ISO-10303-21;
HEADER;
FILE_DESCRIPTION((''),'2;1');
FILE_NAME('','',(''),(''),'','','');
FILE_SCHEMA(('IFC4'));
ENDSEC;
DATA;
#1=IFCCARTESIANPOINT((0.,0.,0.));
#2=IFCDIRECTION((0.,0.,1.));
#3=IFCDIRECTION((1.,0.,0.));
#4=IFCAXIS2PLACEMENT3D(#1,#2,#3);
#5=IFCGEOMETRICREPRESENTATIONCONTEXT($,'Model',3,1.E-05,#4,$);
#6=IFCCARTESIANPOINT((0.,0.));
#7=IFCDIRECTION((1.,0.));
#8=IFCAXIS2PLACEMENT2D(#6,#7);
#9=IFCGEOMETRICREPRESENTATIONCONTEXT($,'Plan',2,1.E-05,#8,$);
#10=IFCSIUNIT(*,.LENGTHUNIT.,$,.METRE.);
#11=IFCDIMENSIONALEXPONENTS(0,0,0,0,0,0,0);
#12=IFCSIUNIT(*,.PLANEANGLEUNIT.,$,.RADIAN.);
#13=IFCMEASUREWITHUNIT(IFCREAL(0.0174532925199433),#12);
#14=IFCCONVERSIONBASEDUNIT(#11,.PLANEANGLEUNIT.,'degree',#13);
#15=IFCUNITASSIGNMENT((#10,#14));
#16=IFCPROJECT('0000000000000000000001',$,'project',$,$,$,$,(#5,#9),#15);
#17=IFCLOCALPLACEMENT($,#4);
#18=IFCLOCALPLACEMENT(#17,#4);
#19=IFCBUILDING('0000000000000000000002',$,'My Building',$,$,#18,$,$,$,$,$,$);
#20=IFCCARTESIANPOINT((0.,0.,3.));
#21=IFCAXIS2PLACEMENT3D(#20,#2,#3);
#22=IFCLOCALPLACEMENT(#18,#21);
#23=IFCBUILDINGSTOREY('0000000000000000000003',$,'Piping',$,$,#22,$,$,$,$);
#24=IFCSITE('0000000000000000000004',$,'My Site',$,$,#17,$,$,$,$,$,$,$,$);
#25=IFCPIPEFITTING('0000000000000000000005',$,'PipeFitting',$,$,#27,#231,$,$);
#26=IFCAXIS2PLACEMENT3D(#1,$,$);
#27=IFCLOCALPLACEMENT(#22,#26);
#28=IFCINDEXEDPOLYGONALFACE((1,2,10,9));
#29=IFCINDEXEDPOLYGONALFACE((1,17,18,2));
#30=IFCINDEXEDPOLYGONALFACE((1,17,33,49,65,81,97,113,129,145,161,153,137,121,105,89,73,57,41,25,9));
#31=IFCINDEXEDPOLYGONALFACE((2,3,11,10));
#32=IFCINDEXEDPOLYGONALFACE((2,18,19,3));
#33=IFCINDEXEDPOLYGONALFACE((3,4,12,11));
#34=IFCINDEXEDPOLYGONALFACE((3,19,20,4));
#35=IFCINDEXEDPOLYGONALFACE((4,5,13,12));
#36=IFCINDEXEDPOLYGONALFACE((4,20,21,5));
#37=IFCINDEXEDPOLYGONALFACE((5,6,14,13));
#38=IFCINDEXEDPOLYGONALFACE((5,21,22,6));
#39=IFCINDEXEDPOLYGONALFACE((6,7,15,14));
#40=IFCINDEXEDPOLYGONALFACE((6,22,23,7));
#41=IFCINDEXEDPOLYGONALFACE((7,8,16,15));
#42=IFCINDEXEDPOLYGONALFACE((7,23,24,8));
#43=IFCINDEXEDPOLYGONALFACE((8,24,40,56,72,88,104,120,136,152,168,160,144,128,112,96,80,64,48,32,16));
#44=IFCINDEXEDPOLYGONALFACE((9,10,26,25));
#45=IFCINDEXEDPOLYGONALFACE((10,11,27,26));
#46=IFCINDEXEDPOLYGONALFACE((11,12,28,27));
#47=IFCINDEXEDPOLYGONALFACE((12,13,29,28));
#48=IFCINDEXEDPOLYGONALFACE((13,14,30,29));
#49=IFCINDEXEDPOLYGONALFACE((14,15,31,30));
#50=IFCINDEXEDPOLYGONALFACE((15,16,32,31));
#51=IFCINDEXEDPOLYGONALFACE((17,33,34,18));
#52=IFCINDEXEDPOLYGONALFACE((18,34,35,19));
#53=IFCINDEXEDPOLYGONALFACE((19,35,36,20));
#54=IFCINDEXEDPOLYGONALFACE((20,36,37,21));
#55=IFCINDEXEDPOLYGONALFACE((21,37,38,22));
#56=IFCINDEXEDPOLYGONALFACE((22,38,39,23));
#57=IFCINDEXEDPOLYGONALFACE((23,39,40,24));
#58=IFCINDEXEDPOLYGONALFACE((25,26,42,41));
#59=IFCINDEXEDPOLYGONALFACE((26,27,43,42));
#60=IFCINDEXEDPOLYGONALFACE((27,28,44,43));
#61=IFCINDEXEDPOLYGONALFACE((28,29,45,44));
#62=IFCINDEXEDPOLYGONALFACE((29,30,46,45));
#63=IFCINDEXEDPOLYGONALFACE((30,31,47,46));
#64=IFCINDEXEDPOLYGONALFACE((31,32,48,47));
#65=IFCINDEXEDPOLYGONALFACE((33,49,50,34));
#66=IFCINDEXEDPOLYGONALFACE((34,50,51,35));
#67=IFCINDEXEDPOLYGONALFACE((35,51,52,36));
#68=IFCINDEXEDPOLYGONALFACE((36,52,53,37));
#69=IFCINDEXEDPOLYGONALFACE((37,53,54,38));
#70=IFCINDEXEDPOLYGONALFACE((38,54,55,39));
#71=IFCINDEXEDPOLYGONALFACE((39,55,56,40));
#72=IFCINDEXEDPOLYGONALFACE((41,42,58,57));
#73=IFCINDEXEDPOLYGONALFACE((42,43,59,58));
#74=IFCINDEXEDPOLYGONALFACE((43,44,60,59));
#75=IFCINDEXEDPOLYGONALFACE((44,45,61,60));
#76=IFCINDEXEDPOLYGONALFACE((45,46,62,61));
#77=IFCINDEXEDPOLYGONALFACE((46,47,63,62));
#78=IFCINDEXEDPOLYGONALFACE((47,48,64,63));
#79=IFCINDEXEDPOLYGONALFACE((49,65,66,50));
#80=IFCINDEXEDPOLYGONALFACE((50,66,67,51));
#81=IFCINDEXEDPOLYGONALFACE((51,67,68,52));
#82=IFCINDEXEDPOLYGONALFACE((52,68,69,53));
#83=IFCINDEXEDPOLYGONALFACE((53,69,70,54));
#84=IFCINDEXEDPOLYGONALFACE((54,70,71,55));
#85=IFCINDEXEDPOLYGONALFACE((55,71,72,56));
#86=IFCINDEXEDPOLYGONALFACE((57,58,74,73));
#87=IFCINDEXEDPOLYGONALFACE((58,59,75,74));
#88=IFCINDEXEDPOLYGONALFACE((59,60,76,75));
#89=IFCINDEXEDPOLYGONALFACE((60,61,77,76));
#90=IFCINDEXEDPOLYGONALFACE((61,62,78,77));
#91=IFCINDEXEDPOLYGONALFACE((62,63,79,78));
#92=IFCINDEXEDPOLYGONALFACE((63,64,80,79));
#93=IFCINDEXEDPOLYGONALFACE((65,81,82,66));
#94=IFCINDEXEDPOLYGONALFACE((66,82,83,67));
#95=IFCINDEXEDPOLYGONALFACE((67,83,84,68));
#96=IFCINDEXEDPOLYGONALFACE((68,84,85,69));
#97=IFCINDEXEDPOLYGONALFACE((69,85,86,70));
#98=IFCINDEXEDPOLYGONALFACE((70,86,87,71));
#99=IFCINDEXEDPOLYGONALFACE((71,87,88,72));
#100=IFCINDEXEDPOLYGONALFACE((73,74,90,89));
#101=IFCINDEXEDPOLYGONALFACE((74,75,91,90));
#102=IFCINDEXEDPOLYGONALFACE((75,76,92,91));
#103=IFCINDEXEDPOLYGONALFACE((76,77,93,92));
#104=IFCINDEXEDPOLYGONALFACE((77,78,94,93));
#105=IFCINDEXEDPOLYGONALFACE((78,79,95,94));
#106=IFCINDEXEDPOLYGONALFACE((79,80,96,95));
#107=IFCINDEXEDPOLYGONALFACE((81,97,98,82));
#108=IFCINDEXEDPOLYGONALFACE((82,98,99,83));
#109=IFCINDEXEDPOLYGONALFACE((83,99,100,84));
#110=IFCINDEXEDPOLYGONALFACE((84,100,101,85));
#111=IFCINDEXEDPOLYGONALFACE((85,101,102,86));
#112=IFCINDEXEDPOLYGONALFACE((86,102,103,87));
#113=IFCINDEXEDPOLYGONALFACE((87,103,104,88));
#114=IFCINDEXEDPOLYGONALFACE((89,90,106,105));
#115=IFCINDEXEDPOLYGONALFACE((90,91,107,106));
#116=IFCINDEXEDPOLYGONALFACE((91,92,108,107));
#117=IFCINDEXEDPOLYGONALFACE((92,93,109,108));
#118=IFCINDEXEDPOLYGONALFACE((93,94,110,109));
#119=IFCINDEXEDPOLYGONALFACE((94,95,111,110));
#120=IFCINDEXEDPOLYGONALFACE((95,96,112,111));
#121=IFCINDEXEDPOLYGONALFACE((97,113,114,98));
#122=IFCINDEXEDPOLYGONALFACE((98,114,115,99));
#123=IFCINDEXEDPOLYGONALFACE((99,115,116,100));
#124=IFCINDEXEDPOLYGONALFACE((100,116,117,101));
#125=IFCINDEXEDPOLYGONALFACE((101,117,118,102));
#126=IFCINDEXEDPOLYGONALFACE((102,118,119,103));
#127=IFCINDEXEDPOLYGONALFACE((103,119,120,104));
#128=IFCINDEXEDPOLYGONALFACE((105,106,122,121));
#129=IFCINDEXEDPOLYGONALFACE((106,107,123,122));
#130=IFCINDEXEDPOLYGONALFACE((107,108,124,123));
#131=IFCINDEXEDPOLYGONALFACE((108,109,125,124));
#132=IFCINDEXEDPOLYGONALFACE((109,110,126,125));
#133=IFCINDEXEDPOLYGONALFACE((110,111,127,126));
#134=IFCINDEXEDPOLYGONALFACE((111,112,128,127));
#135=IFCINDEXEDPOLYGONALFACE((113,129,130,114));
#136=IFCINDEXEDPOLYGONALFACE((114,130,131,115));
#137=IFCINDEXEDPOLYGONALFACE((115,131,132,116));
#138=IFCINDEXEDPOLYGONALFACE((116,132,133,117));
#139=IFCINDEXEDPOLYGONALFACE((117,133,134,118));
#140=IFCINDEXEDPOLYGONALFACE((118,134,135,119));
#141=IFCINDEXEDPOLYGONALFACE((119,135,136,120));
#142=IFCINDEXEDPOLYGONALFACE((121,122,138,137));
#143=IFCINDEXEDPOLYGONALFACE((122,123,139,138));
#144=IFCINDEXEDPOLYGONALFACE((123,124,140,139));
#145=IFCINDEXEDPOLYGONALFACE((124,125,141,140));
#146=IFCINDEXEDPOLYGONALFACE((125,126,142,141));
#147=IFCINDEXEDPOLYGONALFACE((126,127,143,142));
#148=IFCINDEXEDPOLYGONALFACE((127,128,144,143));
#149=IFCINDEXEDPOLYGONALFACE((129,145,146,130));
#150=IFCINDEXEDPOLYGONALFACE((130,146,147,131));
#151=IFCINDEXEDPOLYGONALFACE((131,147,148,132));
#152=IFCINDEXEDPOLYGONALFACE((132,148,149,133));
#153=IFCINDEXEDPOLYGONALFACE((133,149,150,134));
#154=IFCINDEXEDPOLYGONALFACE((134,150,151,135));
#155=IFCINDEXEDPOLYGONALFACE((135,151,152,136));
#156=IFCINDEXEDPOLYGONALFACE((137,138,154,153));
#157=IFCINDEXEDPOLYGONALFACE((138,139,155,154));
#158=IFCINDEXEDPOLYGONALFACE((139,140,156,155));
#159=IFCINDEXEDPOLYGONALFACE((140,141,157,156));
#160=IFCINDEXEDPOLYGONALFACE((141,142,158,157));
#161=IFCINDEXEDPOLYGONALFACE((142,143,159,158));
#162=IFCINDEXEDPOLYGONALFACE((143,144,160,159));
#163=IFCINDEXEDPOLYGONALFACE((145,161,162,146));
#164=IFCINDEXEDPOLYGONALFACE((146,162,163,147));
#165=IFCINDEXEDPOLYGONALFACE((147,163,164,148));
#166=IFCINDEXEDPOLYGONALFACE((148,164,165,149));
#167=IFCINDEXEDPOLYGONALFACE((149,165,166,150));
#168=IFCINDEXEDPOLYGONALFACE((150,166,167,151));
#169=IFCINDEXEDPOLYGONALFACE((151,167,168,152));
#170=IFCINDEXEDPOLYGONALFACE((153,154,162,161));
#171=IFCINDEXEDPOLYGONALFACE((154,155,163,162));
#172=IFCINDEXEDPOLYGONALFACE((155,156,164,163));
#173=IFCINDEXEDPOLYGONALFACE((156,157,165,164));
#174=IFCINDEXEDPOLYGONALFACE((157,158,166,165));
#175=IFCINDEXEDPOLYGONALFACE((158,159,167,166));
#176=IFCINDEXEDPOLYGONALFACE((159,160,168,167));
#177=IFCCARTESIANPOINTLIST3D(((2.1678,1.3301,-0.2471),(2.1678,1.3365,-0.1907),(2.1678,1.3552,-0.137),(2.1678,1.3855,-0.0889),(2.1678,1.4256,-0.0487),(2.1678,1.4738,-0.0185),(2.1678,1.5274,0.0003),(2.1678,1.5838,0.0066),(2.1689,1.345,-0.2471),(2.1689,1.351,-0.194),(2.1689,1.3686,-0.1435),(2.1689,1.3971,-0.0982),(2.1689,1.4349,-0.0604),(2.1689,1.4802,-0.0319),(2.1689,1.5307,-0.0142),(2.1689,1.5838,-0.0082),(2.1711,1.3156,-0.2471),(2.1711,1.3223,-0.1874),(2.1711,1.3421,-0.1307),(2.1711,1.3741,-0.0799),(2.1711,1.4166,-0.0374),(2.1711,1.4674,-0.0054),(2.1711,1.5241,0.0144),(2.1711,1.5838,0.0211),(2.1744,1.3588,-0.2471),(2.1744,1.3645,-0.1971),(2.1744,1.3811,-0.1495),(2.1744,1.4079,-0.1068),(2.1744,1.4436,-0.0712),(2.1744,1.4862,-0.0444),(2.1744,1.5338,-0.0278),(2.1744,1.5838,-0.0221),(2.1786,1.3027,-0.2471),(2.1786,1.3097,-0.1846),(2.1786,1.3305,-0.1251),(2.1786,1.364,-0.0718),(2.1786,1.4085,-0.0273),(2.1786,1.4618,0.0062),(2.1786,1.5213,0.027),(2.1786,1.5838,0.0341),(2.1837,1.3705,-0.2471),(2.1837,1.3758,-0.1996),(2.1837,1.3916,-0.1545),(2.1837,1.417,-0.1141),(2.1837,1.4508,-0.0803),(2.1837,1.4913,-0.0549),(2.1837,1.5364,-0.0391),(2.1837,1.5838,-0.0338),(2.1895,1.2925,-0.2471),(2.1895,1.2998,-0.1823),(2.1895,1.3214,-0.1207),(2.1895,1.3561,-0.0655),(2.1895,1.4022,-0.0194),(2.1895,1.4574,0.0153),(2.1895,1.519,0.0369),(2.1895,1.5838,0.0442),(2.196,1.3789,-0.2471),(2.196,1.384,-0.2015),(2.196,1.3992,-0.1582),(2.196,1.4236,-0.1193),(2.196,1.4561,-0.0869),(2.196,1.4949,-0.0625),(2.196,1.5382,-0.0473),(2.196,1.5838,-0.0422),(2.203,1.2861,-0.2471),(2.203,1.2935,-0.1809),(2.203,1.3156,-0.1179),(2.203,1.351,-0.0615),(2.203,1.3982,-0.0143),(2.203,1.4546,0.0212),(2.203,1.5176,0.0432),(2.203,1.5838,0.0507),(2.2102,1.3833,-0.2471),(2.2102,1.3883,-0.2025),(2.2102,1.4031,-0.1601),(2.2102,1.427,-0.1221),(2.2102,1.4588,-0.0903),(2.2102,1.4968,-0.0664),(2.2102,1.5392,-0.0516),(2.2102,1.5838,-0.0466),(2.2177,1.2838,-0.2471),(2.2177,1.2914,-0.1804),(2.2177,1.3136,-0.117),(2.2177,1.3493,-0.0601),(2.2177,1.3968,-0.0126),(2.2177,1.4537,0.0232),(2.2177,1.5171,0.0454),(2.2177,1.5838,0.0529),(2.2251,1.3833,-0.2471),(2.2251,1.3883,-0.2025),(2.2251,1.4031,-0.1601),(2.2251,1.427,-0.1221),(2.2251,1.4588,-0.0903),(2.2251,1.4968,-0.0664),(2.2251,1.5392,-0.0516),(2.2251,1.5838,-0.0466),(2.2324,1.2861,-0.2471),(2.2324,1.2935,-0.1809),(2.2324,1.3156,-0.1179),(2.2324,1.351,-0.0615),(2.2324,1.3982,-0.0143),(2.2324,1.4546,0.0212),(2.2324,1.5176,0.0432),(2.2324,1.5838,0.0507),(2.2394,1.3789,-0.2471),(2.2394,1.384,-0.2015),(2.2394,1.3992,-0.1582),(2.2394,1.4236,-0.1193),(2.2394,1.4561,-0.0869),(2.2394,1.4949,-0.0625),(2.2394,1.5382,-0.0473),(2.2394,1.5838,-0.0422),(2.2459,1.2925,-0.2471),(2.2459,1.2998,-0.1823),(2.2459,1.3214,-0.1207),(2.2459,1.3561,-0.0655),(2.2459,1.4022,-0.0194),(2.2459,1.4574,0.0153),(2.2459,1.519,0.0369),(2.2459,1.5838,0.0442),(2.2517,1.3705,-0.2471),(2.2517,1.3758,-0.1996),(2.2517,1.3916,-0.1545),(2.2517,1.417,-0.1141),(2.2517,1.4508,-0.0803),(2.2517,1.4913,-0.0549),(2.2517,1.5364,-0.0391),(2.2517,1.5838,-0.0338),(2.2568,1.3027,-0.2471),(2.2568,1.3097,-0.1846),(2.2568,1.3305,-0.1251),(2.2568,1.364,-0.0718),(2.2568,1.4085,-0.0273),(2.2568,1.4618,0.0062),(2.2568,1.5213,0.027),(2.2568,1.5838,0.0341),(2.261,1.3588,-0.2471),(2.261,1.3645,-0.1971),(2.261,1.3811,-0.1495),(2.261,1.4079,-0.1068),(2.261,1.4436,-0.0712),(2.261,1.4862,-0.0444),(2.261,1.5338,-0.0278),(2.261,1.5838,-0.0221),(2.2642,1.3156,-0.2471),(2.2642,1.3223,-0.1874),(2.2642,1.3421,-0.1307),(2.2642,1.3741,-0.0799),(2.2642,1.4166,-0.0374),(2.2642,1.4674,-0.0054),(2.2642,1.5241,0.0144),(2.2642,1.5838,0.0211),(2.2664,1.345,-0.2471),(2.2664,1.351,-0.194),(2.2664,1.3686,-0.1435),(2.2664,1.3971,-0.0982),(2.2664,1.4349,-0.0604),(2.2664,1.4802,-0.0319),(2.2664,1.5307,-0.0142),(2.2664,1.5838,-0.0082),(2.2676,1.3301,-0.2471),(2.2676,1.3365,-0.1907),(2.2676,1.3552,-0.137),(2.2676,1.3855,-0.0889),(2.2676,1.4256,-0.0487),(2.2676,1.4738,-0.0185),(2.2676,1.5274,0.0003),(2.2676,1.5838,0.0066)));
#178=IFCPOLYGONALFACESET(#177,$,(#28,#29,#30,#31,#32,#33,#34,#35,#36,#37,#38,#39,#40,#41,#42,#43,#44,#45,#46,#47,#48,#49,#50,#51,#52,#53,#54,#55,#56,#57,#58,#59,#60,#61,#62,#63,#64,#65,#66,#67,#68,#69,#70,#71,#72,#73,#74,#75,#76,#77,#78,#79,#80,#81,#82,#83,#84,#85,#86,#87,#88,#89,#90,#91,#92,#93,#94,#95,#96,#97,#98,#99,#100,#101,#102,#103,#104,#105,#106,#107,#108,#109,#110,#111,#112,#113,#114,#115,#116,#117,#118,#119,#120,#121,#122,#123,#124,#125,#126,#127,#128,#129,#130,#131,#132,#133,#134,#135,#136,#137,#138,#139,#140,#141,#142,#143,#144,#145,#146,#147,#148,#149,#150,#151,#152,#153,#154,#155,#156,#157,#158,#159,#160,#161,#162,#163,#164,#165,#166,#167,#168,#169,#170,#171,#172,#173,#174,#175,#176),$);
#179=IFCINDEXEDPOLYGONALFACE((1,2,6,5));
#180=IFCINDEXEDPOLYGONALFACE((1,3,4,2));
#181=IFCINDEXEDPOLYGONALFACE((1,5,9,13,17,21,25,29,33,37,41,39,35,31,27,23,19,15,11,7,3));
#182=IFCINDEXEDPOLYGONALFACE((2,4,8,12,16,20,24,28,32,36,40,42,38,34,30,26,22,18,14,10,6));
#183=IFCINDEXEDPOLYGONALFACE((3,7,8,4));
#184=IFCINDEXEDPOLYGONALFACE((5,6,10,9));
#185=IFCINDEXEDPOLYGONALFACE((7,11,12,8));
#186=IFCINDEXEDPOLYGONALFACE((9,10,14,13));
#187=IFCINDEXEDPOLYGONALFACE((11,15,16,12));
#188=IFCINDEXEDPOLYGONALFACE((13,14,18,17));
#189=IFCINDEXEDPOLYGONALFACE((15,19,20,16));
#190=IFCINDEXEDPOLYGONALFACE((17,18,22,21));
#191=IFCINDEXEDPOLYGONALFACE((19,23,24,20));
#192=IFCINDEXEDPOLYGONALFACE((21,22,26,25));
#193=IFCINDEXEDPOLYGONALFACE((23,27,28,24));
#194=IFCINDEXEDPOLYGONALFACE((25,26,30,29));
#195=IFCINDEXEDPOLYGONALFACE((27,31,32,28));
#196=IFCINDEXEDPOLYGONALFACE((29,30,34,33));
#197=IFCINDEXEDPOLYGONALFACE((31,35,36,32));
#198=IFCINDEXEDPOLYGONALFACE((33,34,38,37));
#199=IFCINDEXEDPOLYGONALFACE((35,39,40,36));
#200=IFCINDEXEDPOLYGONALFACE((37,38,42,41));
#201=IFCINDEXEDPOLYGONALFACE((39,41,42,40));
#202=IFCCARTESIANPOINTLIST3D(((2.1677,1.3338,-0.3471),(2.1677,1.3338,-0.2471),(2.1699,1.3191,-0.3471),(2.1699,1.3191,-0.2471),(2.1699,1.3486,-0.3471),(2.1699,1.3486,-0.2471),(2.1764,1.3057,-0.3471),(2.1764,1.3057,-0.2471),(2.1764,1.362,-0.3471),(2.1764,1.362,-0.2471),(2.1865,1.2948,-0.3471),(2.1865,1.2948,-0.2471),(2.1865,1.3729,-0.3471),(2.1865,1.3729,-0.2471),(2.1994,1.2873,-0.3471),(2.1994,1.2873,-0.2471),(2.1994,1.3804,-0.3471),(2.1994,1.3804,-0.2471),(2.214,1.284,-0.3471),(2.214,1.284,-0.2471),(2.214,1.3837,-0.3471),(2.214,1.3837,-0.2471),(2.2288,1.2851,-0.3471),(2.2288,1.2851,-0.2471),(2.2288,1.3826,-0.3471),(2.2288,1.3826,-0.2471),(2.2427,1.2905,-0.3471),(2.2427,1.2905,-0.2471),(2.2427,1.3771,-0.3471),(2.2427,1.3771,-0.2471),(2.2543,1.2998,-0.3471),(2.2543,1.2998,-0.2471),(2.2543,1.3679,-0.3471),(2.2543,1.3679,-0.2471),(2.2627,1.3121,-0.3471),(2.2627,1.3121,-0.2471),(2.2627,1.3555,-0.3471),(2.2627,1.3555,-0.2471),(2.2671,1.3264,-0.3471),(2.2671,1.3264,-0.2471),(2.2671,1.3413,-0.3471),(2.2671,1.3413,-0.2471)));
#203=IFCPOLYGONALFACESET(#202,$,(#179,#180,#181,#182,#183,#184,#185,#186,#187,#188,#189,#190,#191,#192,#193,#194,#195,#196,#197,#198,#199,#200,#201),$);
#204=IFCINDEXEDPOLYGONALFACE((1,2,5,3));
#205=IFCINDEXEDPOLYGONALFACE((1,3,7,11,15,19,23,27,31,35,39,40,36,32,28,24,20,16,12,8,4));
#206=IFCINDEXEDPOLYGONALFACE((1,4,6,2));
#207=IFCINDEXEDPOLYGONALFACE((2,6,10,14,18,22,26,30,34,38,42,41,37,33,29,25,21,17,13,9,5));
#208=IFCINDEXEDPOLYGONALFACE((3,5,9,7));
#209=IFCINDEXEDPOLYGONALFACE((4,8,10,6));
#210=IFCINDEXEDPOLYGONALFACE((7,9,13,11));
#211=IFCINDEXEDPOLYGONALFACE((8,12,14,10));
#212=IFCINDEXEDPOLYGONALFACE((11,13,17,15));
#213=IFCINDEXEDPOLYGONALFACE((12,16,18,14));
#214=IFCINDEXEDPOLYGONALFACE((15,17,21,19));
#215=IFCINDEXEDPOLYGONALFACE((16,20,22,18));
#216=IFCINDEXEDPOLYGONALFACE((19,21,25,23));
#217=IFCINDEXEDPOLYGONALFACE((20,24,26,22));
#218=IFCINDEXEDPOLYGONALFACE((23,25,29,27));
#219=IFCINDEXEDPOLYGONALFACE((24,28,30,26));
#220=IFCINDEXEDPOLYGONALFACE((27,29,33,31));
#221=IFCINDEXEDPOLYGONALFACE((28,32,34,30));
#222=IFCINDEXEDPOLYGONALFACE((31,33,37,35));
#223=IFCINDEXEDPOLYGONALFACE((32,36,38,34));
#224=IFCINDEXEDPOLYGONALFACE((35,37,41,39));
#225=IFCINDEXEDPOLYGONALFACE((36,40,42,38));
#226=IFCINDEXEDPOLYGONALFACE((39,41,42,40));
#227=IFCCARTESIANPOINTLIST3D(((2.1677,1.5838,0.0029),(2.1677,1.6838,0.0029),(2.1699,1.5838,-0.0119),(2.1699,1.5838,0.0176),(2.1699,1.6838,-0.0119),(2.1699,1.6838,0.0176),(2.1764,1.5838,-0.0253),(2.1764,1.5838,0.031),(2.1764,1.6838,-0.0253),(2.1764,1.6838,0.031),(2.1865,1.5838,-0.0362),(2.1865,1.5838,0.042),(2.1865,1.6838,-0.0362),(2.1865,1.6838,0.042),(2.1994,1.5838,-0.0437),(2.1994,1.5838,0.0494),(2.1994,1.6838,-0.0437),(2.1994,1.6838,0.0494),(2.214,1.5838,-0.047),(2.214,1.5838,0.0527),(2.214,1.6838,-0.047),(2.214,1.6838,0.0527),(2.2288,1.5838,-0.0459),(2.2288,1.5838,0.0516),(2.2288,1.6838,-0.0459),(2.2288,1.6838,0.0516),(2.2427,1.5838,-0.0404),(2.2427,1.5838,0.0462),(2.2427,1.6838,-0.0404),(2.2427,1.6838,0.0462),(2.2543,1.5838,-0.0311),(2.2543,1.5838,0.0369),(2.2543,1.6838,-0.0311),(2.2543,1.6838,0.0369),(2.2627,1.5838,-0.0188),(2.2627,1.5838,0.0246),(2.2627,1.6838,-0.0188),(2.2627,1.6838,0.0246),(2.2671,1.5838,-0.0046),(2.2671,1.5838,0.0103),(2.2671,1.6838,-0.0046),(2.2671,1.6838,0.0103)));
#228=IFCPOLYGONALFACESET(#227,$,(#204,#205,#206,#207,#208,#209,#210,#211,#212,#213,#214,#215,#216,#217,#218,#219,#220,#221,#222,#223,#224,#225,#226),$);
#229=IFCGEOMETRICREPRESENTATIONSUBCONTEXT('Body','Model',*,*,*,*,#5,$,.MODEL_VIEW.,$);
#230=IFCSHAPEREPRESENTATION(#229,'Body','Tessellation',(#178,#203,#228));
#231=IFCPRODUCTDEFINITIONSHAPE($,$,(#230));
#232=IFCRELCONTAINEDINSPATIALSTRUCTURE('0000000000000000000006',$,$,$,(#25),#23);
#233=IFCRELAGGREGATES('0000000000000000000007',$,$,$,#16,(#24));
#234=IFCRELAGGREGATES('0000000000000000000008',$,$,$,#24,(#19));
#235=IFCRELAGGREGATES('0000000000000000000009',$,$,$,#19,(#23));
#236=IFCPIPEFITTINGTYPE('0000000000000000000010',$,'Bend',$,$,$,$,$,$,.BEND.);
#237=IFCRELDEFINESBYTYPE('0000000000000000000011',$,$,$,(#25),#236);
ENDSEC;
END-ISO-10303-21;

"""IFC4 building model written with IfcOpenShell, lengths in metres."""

from ifc_helpers import new_model, entity, si_unit, converted_unit, frame, origin_with_axes, origin_2d_with_axis, place, context, subcontext, project, spatial, circle, extrude, source, transform, mapped, type_object, type_shapes, element, save


model = new_model("IFC4")

# Units and contexts
model_context = context("Model", 3, precision=1e-05, world=origin_with_axes())
plan_context = context("Plan", 2, precision=1e-05, world=origin_2d_with_axis())
body_context = subcontext(model_context, "Body", "Model", "MODEL_VIEW")
ifc_project = project(units=[si_unit("LENGTHUNIT", "METRE"), converted_unit("PLANEANGLEUNIT", "degree", entity("IfcReal", 0.0174532925199433), si_unit("PLANEANGLEUNIT", "RADIAN"), dimensions=[0, 0, 0, 0, 0, 0, 0])], contexts=[model_context, plan_context])

# Site, building, storey
site_placement = place(None, origin_with_axes())
site = spatial("IfcSite", under=ifc_project, at=site_placement, Name="My Site")
building_placement = place(site_placement, origin_with_axes())
building = spatial("IfcBuilding", under=site, at=building_placement, Name="My Building")
storey_placement = place(building_placement, frame((0.0, 0.0, 3.0), z_axis=(0.0, 0.0, 1.0), x_axis=(1.0, 0.0, 0.0)))
storey = spatial("IfcBuildingStorey", under=building, at=storey_placement, Name="Piping")

# Pipe fitting
pipe_fitting_type_1 = type_object("IfcPipeFittingType", Name="Bend", PredefinedType="BEND")
shared_shape = source(origin_with_axes(), body_context, "Body", "SolidModel", [
    entity("IfcSweptDiskSolid", entity("IfcIndexedPolyCurve", entity("IfcCartesianPointList3D", [[0.0, 0.0, -0.1], [0.0, 0.0732, -0.2768], [0.0, 0.25, -0.35]]), [entity("IfcArcIndex", [1, 2, 3])]), 0.05),
    extrude(circle(Radius=0.05), origin_with_axes(), (0.0, 0.0, -1.0), 0.1),
    extrude(circle(Radius=0.05), frame((0.0, 0.25, -0.35), z_axis=(0.0, 1.0, 0.0), x_axis=(1.0, 0.0, 0.0)), (0.0, 0.0, 1.0), 0.1),
])
type_shapes(pipe_fitting_type_1, [shared_shape])
for number, where, z_axis, x_axis, name in (
    (1, (2.2177, 1.3338, -0.3471), (0.0, 0.0, -1.0), (-1.0, 0.0, 0.0), "PipeFitting"),
):
    element("IfcPipeFitting", number, at=place(storey_placement, frame(where, z_axis=z_axis, x_axis=x_axis)), inside=storey, type_object=pipe_fitting_type_1, Name=name, context=body_context, shape_type="MappedRepresentation", body=[
        mapped(shared_shape, transform((0.0, 0.0, 0.0), x_axis=(1.0, 0.0, 0.0), y_axis=(0.0, 1.0, 0.0), z_axis=(0.0, 0.0, 1.0), scale=1.0)),
    ])

save(model, "model.ifc")
